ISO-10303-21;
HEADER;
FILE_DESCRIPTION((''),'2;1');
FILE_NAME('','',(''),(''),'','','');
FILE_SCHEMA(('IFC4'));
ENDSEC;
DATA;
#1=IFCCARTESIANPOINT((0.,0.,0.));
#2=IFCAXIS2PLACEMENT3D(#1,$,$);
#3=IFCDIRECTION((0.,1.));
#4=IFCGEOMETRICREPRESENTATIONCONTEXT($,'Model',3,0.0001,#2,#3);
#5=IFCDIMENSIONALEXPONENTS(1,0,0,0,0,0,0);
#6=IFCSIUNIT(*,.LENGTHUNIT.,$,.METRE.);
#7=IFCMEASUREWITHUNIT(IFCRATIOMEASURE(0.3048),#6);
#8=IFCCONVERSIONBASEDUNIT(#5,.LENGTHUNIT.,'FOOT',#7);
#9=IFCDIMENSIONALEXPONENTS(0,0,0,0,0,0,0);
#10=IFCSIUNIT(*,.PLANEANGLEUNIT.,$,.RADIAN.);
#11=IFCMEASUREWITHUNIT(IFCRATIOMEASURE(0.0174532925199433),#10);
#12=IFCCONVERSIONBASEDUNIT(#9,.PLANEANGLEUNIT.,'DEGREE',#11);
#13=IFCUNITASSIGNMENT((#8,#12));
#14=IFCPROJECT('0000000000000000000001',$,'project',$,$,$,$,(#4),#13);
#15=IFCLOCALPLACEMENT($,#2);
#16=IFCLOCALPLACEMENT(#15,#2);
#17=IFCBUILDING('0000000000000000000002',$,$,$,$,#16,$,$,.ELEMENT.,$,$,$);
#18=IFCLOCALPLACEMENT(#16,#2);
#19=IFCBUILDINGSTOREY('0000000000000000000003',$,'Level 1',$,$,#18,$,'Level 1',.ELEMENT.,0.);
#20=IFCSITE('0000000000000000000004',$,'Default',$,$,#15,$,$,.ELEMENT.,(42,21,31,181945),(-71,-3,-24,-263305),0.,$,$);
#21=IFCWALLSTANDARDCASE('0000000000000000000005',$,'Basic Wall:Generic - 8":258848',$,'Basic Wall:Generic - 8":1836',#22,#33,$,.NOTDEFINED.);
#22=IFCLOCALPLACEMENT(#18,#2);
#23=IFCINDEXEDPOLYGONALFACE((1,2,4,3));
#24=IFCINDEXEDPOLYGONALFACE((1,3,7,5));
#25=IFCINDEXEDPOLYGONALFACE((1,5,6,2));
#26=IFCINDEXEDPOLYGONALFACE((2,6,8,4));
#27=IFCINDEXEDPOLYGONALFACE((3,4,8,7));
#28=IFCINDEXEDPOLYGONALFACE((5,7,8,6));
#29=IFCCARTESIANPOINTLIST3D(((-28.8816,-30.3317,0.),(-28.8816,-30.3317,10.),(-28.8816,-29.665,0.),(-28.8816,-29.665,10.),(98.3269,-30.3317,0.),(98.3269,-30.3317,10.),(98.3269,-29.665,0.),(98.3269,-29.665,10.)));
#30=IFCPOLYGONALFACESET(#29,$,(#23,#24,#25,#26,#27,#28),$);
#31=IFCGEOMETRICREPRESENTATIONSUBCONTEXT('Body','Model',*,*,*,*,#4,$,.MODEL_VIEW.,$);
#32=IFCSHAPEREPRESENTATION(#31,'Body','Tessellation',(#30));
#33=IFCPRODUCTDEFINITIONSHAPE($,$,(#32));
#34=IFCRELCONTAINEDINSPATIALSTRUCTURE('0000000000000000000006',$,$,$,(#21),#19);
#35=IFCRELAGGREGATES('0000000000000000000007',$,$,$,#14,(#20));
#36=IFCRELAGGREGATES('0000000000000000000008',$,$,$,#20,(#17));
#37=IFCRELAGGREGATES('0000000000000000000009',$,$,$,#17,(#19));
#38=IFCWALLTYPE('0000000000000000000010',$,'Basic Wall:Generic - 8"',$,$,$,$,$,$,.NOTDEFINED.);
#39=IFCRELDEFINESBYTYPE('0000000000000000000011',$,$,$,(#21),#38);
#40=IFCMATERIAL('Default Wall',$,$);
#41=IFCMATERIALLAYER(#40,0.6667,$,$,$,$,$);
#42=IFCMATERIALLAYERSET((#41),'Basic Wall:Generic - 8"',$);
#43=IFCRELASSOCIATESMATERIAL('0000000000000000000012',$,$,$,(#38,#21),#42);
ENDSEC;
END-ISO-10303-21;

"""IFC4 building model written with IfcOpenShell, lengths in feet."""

from ifc_helpers import new_model, entity, si_unit, converted_unit, direction, frame, frame_2d, origin, place, context, subcontext, project, spatial, rectangle, extrude, material, layer, layer_set, layer_usage, type_object, element, save


model = new_model("IFC4")

# Units and contexts
model_context = context("Model", 3, precision=0.0001, world=origin(), true_north=direction((0.0, 1.0)))
body_context = subcontext(model_context, "Body", "Model", "MODEL_VIEW")
ifc_project = project(units=[converted_unit("LENGTHUNIT", "FOOT", entity("IfcRatioMeasure", 0.3048), si_unit("LENGTHUNIT", "METRE"), dimensions=[1, 0, 0, 0, 0, 0, 0]), converted_unit("PLANEANGLEUNIT", "DEGREE", entity("IfcRatioMeasure", 0.0174532925199433), si_unit("PLANEANGLEUNIT", "RADIAN"), dimensions=[0, 0, 0, 0, 0, 0, 0])], contexts=[model_context])

# Site, building, storey
site_placement = place(None, origin())
site = spatial("IfcSite", under=ifc_project, at=site_placement, Name="Default", CompositionType="ELEMENT", RefLatitude=(42, 21, 31, 181945), RefLongitude=(-71, -3, -24, -263305), RefElevation=0.0)
building_placement = place(site_placement, origin())
building = spatial("IfcBuilding", under=site, at=building_placement, CompositionType="ELEMENT")
storey_placement = place(building_placement, origin())
storey = spatial("IfcBuildingStorey", under=building, at=storey_placement, Name="Level 1", LongName="Level 1", CompositionType="ELEMENT", Elevation=0.0)

# Wall
ifc_material_1 = material(Name="Default Wall")
ifc_layer = layer(ifc_material_1, 0.6667)
ifc_layer_set = layer_set([ifc_layer], Name="Basic Wall:Generic - 8\"")
ifc_layer_usage = layer_usage(ifc_layer_set, "AXIS2", "NEGATIVE", 0.3333)
wall_type = type_object("IfcWallType", Name="Basic Wall:Generic - 8\"", PredefinedType="NOTDEFINED", material=ifc_layer_set)
wall_placement = place(storey_placement, frame((-28.8816, -29.9983, 0.0)))
element("IfcWallStandardCase", 1, at=wall_placement, inside=storey, type_object=wall_type, material=ifc_layer_usage, Name="Basic Wall:Generic - 8\":258848", ObjectType="Basic Wall:Generic - 8\":1836", PredefinedType="NOTDEFINED", context=body_context, shape_type="SweptSolid", body=[
    extrude(rectangle(XDim=127.2085, YDim=0.6667, at=frame_2d((63.6043, 0.0), x_axis=(-1.0, 0.0))), origin(), (0.0, 0.0, 1.0), 10.0),
])

save(model, "model.ifc")
